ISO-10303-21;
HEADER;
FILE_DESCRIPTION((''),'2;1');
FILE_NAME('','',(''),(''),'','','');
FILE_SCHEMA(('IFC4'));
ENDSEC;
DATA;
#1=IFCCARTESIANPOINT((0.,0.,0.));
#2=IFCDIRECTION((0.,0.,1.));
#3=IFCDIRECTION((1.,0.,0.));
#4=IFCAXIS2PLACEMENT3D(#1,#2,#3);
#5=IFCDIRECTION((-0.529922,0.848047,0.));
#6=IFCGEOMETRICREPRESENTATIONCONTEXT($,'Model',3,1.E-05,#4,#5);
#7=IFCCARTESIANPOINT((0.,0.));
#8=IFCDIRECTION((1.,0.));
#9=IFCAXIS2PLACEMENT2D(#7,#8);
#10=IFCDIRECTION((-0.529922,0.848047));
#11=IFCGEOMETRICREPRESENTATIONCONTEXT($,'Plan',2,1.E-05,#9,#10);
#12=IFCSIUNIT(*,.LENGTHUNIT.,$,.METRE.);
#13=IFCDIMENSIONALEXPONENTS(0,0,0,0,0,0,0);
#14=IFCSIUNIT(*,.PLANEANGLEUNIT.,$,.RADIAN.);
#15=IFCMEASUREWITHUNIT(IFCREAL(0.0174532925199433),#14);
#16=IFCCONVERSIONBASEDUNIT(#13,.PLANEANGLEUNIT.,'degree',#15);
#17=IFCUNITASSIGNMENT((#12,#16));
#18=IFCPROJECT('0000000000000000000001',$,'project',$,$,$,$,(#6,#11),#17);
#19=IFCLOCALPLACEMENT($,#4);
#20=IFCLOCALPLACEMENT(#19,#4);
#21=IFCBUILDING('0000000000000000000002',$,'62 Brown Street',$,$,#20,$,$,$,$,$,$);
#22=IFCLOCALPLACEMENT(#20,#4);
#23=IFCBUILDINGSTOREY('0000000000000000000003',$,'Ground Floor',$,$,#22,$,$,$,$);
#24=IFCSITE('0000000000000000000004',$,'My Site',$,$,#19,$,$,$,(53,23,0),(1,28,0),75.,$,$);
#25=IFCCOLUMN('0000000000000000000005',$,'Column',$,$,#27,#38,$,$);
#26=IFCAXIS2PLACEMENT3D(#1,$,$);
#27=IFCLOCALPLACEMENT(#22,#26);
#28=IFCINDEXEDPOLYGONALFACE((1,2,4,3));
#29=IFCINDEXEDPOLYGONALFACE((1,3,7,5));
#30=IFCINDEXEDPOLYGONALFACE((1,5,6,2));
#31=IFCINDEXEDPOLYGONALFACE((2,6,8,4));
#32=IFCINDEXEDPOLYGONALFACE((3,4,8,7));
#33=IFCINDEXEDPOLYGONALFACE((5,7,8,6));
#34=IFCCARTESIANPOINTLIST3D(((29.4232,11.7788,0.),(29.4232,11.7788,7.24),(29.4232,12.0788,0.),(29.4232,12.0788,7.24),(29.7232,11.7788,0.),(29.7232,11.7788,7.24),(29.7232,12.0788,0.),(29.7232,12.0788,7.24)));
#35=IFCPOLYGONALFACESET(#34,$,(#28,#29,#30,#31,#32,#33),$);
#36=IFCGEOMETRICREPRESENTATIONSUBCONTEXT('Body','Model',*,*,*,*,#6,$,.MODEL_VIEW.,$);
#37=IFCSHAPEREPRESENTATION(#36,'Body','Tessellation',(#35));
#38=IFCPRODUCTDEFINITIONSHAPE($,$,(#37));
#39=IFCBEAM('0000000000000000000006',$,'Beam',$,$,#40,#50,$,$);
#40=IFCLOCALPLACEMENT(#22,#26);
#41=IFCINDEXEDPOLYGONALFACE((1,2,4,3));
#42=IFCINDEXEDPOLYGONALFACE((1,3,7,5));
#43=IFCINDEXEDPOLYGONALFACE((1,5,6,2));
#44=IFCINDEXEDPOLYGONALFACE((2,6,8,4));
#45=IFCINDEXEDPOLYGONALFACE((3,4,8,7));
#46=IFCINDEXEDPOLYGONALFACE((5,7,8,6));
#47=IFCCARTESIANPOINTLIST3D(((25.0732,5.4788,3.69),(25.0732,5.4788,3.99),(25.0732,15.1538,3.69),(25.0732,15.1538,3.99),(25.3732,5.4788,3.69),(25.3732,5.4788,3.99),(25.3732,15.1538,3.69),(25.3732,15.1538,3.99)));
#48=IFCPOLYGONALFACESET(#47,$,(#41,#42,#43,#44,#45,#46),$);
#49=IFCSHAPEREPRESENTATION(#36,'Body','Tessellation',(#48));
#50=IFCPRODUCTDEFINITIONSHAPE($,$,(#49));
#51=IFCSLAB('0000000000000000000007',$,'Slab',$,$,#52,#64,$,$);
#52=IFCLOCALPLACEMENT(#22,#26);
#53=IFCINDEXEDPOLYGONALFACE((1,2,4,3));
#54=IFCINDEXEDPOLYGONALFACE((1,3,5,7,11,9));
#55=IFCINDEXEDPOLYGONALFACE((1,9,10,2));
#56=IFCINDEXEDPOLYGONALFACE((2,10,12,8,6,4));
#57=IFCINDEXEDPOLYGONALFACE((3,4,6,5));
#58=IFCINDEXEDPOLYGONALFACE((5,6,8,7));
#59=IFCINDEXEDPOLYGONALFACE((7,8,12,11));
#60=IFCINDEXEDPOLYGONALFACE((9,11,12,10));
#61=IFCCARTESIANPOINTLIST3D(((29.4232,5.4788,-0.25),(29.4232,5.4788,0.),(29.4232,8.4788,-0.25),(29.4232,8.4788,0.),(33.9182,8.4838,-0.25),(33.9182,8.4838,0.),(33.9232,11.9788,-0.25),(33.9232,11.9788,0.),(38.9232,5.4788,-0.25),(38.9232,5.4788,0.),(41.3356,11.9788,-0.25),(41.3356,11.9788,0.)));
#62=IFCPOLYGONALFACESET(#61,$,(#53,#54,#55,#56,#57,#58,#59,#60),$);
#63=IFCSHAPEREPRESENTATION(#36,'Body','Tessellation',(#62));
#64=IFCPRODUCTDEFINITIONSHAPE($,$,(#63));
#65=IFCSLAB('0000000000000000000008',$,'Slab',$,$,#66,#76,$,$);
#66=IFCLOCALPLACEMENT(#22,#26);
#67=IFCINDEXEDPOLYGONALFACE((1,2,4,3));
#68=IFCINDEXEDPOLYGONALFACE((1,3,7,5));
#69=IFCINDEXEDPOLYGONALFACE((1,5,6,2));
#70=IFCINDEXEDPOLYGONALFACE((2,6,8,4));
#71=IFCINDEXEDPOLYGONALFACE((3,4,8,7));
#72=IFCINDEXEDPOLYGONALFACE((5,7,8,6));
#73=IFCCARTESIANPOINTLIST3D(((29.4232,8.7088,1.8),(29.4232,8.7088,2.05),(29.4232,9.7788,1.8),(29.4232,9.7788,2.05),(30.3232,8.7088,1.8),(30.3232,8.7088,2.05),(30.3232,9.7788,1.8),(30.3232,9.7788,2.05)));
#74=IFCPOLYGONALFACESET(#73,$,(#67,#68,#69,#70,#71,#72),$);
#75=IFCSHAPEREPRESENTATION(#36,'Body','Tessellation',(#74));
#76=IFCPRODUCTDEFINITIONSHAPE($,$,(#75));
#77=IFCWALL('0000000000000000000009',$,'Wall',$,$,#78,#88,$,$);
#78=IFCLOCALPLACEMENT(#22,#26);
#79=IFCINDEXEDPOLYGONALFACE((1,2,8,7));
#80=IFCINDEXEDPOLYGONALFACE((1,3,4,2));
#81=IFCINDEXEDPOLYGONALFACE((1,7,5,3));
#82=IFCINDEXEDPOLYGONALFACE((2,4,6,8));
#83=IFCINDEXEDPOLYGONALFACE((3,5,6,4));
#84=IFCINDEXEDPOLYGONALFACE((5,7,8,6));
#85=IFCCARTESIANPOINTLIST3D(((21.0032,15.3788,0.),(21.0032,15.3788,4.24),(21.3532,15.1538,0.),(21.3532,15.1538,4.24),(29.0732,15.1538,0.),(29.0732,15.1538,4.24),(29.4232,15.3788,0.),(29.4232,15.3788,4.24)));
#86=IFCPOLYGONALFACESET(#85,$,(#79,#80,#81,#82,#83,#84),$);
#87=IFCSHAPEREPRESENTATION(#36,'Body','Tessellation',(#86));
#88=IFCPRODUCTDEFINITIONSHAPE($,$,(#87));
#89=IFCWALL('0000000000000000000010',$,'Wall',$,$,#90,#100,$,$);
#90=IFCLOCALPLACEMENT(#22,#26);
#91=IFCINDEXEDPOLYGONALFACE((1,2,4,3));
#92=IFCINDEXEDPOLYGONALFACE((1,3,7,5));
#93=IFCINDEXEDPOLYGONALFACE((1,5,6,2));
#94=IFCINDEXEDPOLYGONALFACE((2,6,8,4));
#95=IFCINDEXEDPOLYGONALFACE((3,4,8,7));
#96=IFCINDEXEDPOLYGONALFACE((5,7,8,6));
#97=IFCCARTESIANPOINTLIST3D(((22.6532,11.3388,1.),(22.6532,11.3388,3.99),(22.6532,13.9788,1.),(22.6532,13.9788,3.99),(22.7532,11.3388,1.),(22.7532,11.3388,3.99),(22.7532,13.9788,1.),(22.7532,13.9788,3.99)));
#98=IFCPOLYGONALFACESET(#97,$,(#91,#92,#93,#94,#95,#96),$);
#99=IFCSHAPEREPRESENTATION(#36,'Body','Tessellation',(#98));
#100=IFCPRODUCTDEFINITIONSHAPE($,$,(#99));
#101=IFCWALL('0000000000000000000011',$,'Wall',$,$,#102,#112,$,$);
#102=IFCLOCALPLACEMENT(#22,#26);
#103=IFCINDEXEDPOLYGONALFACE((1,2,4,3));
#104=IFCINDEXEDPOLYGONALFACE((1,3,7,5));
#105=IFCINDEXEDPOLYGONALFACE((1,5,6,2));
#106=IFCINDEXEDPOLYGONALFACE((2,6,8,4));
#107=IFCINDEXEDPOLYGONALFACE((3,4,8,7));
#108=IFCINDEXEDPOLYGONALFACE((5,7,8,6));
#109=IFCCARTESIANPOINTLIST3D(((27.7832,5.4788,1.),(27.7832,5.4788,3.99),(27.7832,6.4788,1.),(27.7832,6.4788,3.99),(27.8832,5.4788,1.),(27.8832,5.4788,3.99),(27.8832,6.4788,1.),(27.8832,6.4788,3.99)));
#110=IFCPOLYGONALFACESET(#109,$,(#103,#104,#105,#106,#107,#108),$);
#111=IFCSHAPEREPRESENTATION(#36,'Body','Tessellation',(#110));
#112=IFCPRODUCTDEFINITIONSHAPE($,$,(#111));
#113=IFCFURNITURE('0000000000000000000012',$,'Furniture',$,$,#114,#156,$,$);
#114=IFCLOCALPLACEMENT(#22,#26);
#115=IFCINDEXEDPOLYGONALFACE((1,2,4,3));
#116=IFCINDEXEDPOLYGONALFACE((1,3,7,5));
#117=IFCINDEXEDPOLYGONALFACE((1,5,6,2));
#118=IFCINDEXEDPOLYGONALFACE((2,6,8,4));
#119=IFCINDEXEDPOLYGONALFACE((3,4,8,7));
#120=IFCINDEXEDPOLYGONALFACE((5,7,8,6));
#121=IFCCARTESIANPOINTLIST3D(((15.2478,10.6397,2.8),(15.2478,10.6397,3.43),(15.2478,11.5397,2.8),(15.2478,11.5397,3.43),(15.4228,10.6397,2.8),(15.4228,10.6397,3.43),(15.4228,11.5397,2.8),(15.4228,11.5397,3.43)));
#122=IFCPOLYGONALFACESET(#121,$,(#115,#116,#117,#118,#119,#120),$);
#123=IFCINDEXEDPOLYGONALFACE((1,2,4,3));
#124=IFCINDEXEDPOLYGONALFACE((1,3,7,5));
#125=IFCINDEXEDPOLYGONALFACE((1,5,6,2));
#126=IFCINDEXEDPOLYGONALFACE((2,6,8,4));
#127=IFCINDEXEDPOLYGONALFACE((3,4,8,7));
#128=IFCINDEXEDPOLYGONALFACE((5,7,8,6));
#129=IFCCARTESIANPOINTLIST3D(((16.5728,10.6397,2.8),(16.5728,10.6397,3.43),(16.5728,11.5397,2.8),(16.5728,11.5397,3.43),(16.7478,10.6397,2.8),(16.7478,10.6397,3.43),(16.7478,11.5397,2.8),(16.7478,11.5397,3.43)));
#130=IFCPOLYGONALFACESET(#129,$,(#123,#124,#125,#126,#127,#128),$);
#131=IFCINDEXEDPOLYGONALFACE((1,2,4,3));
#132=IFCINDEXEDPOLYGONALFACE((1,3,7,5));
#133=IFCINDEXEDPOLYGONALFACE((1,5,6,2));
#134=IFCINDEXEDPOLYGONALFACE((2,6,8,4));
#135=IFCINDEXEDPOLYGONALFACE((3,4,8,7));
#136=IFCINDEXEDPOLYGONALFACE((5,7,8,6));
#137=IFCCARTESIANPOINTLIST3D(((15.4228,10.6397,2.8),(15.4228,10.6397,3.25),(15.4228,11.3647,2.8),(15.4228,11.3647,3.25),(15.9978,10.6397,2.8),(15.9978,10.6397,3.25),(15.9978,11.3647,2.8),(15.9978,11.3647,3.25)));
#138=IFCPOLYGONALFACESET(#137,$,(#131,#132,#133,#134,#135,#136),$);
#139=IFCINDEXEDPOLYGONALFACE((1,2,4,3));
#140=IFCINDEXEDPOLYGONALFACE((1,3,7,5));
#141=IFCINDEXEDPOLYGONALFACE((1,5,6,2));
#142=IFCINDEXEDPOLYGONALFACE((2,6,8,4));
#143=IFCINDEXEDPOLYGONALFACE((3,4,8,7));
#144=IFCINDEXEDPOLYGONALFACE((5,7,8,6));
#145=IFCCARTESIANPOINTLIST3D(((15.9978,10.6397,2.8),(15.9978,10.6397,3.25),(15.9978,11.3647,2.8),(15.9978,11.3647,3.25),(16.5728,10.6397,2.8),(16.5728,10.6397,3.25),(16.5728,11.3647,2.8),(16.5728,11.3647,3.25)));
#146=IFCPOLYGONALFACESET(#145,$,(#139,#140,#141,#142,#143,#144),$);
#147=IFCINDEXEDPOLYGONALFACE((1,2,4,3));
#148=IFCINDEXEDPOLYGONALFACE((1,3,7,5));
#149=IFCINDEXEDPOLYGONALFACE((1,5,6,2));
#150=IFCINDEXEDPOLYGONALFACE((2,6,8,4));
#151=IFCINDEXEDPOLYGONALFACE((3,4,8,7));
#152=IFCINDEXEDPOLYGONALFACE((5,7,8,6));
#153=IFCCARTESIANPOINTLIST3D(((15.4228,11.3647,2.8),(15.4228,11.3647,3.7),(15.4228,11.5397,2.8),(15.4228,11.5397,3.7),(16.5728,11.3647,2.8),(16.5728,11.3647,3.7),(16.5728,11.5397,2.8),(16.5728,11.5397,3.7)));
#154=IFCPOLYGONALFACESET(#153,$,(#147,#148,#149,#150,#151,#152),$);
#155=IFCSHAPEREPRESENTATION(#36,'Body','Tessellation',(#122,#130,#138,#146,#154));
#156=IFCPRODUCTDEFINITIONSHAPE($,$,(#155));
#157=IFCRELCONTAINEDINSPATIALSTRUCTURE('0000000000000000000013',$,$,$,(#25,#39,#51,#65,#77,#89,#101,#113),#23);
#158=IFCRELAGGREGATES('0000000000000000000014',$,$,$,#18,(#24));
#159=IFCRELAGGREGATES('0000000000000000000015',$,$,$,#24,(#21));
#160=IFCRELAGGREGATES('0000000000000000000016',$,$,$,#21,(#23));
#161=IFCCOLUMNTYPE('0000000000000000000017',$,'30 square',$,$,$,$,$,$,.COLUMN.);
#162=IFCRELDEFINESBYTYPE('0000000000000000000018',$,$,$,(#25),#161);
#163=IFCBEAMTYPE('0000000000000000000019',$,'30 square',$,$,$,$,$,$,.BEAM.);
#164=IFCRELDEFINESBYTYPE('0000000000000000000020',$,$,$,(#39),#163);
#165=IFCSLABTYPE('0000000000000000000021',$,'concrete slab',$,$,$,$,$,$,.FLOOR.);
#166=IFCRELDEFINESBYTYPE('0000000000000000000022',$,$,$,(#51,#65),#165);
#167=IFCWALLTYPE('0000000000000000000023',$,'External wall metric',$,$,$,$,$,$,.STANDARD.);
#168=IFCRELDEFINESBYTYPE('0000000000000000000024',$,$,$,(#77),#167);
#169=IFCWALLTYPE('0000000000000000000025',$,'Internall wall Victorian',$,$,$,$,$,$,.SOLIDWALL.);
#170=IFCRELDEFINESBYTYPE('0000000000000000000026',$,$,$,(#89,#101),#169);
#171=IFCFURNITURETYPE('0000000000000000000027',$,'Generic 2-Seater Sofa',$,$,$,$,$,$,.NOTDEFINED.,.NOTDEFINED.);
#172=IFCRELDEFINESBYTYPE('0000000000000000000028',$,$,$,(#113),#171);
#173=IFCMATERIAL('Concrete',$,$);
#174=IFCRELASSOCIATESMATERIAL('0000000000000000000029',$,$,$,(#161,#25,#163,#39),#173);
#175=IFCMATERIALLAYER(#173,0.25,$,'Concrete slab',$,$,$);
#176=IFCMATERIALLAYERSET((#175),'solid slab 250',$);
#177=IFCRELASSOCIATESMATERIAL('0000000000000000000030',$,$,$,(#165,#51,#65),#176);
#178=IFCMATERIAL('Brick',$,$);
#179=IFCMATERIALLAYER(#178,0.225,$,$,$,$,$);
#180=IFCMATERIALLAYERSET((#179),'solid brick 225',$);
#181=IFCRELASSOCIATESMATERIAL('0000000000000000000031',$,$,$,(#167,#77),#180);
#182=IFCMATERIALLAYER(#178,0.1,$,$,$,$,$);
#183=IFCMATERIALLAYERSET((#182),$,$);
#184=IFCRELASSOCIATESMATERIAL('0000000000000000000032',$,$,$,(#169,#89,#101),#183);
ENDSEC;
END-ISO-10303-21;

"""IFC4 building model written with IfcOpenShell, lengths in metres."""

from ifc_helpers import new_model, entity, si_unit, converted_unit, direction, frame, origin_with_axes, origin_2d_with_axis, place, context, subcontext, project, spatial, line, indexed_curve, rectangle, outline, extrude, clip, halfspace, shape, source, transform, mapped, material, layer, layer_set, layer_usage, material_profile, profile_set, profile_usage, type_object, type_shapes, element, save


model = new_model("IFC4")

# Units and contexts
model_context = context("Model", 3, precision=1e-05, world=origin_with_axes(), true_north=direction((-0.529922, 0.848047, 0.0)))
plan_context = context("Plan", 2, precision=1e-05, world=origin_2d_with_axis(), true_north=direction((-0.529922, 0.848047)))
body_context_1 = subcontext(model_context, "Body", "Model", "MODEL_VIEW")
body_context_2 = subcontext(plan_context, "Body", "Plan", "PLAN_VIEW")
ifc_project = project(units=[si_unit("LENGTHUNIT", "METRE"), converted_unit("PLANEANGLEUNIT", "degree", entity("IfcReal", 0.0174532925199433), si_unit("PLANEANGLEUNIT", "RADIAN"), dimensions=[0, 0, 0, 0, 0, 0, 0])], contexts=[model_context, plan_context])

# Site, building, storey
site_placement = place(None, origin_with_axes())
site = spatial("IfcSite", under=ifc_project, at=site_placement, Name="My Site", RefLatitude=(53, 23, 0), RefLongitude=(1, 28, 0), RefElevation=75.0)
building_placement = place(site_placement, origin_with_axes())
building = spatial("IfcBuilding", under=site, at=building_placement, Name="62 Brown Street")
storey_placement = place(building_placement, origin_with_axes())
storey = spatial("IfcBuildingStorey", under=building, at=storey_placement, Name="Ground Floor")

# Column
ifc_material_1 = material(Name="Concrete")
ifc_material_profile_1 = material_profile(ifc_material_1, rectangle(XDim=0.3, YDim=0.3))
ifc_profile_set_1 = profile_set([ifc_material_profile_1])
ifc_profile_usage_1 = profile_usage(ifc_profile_set_1, cardinal=5)
column_type = type_object("IfcColumnType", Name="30 square", PredefinedType="COLUMN", material=ifc_profile_set_1)
column_1_placement = place(storey_placement, frame((29.5732, 11.9288, 0.0), z_axis=(0.0, 0.0, 1.0), x_axis=(1.0, 0.0, 0.0)))
element("IfcColumn", 1, at=column_1_placement, inside=storey, type_object=column_type, material=ifc_profile_usage_1, Name="Column", context=body_context_1, shape_type="SweptSolid", body=[
    extrude(rectangle(XDim=0.3, YDim=0.3), origin_with_axes(), (0.0, 0.0, 1.0), 7.24),
])

# Beam
ifc_material_profile_2 = material_profile(ifc_material_1, rectangle(XDim=0.3, YDim=0.3))
ifc_profile_set_2 = profile_set([ifc_material_profile_2])
ifc_profile_usage_2 = profile_usage(ifc_profile_set_2, cardinal=5)
beam_type = type_object("IfcBeamType", Name="30 square", PredefinedType="BEAM", material=ifc_profile_set_2)
beam_placement = place(storey_placement, frame((25.2232, 5.4788, 3.84), z_axis=(0.0, 1.0, 0.0), x_axis=(-1.0, 0.0, 0.0)))
element("IfcBeam", 2, at=beam_placement, inside=storey, type_object=beam_type, material=ifc_profile_usage_2, Name="Beam", context=body_context_1, shape_type="SweptSolid", body=[
    extrude(rectangle(XDim=0.3, YDim=0.3), origin_with_axes(), (0.0, 0.0, 1.0), 9.675),
])

# Slabs
ifc_layer_1 = layer(ifc_material_1, 0.25, Name="Concrete slab")
ifc_layer_set_1 = layer_set([ifc_layer_1], Name="solid slab 250")
ifc_layer_usage_1 = layer_usage(ifc_layer_set_1, "AXIS3", "POSITIVE", 0.0)
slab_type = type_object("IfcSlabType", Name="concrete slab", PredefinedType="FLOOR", material=ifc_layer_set_1)
slab_1_placement = place(storey_placement, frame((29.4232, 5.4788, -0.25), z_axis=(0.0, 0.0, 1.0), x_axis=(1.0, 0.0, 0.0)))
element("IfcSlab", 3, at=slab_1_placement, inside=storey, type_object=slab_type, material=ifc_layer_usage_1, Name="Slab", context=body_context_1, shape_type="SweptSolid", body=[
    extrude(outline(indexed_curve([(0.0, 0.0), (9.5, 0.0), (11.9124, 6.5), (0.0, 3.0), (4.5, 6.5), (4.495, 3.005)], segments=[line(1, 2), line(2, 3), line(3, 5), line(5, 6), line(6, 4), line(4, 1)], self_intersect=False)), None, (0.0, 0.0, 1.0), 0.25),
])
ifc_layer_usage_2 = layer_usage(ifc_layer_set_1, "AXIS3", "POSITIVE", 0.0)
slab_2_placement = place(storey_placement, frame((29.4232, 8.7088, 1.8), z_axis=(0.0, 0.0, 1.0), x_axis=(1.0, 0.0, 0.0)))
element("IfcSlab", 4, at=slab_2_placement, inside=storey, type_object=slab_type, material=ifc_layer_usage_2, Name="Slab", context=body_context_1, shape_type="SweptSolid", body=[
    extrude(outline(indexed_curve([(0.9, 1.07), (0.9, 0.0), (0.0, 0.0), (0.0, 1.07)], segments=[line(3, 2), line(2, 1), line(1, 4), line(4, 3)], self_intersect=False)), None, (0.0, 0.0, 1.0), 0.25),
])

# Walls
ifc_material_2 = material(Name="Brick")
ifc_layer_2 = layer(ifc_material_2, 0.225)
ifc_layer_set_2 = layer_set([ifc_layer_2], Name="solid brick 225")
wall_type_1 = type_object("IfcWallType", Name="External wall metric", PredefinedType="STANDARD", material=ifc_layer_set_2)
ifc_layer_usage_3 = layer_usage(ifc_layer_set_2, "AXIS2", "POSITIVE", 0.0)
wall_1_placement = place(storey_placement, frame((29.4232, 15.3788, 0.0), z_axis=(0.0, 0.0, 1.0), x_axis=(-1.0, 0.0, 0.0)))
element("IfcWall", 5, at=wall_1_placement, inside=storey, type_object=wall_type_1, material=ifc_layer_usage_3, Name="Wall", context=body_context_1, shape_type="Clipping", body=[
    clip(clip(extrude(outline(indexed_curve([(0.0, 0.0), (0.0, 0.225), (8.42, 0.225), (8.42, 0.0), (0.0, 0.0)], self_intersect=False)), origin_with_axes(), (0.0, 0.0, 1.0), 4.24), halfspace(frame((8.42, 0.0, 0.0), z_axis=(0.540756, 0.841179, 0.0), x_axis=(-0.841179, 0.540756, 0.0)), False)), halfspace(frame((0.0, 0.0, 0.0), z_axis=(-0.540758, 0.841178, 0.0), x_axis=(0.841178, 0.540758, 0.0)), False)),
])
ifc_layer_3 = layer(ifc_material_2, 0.1)
ifc_layer_set_3 = layer_set([ifc_layer_3])
ifc_layer_usage_4 = layer_usage(ifc_layer_set_3, "AXIS2", "POSITIVE", 0.0)
wall_type_2 = type_object("IfcWallType", Name="Internall wall Victorian", PredefinedType="SOLIDWALL", material=ifc_layer_set_3)
wall_2_placement = place(storey_placement, frame((22.7532, 11.3388, 1.0), z_axis=(0.0, 0.0, 1.0), x_axis=(0.0, 1.0, 0.0)))
element("IfcWall", 6, at=wall_2_placement, inside=storey, type_object=wall_type_2, material=ifc_layer_usage_4, Name="Wall", context=body_context_1, shape_type="SweptSolid", body=[
    extrude(outline(indexed_curve([(0.0, 0.0), (0.0, 0.1), (2.64, 0.1), (2.64, 0.0), (0.0, 0.0)], self_intersect=False)), origin_with_axes(), (0.0, 0.0, 1.0), 2.99),
])
ifc_layer_usage_5 = layer_usage(ifc_layer_set_3, "AXIS2", "POSITIVE", 0.0)
wall_3_placement = place(storey_placement, frame((27.8832, 5.4788, 1.0), z_axis=(0.0, 0.0, 1.0), x_axis=(0.0, 1.0, 0.0)))
element("IfcWall", 7, at=wall_3_placement, inside=storey, type_object=wall_type_2, material=ifc_layer_usage_5, Name="Wall", context=body_context_1, shape_type="SweptSolid", body=[
    extrude(outline(indexed_curve([(0.0, 0.0), (0.0, 0.1), (1.0, 0.1), (1.0, 0.0), (0.0, 0.0)], self_intersect=False)), origin_with_axes(), (0.0, 0.0, 1.0), 2.99),
])

# Furniture
furniture_type_1 = type_object("IfcFurnitureType", Name="Generic 2-Seater Sofa", AssemblyPlace="NOTDEFINED", PredefinedType="NOTDEFINED")
shared_shape_1 = source(origin_with_axes(), body_context_1, "Body", "SweptSolid", [
    extrude(outline(indexed_curve([(0.0, 0.0), (0.175, 0.0), (0.175, 0.9), (0.0, 0.9)], segments=[line(1, 2, 3, 4, 1)])), frame((-0.75, -0.9, 0.0), z_axis=(0.0, 0.0, 1.0), x_axis=(1.0, 0.0, 0.0)), (0.0, 0.0, 1.0), 0.63),
    extrude(outline(indexed_curve([(0.0, 0.0), (0.175, 0.0), (0.175, 0.9), (0.0, 0.9)], segments=[line(1, 2, 3, 4, 1)])), frame((0.575, -0.9, 0.0), z_axis=(0.0, 0.0, 1.0), x_axis=(1.0, 0.0, 0.0)), (0.0, 0.0, 1.0), 0.63),
    extrude(outline(indexed_curve([(0.175, 0.0), (0.75, 0.0), (0.75, 0.725), (0.175, 0.725)], segments=[line(1, 2, 3, 4, 1)])), frame((-0.75, -0.9, 0.0), z_axis=(0.0, 0.0, 1.0), x_axis=(1.0, 0.0, 0.0)), (0.0, 0.0, 1.0), 0.45),
    extrude(outline(indexed_curve([(0.75, 0.0), (1.325, 0.0), (1.325, 0.725), (0.75, 0.725)], segments=[line(1, 2, 3, 4, 1)])), frame((-0.75, -0.9, 0.0), z_axis=(0.0, 0.0, 1.0), x_axis=(1.0, 0.0, 0.0)), (0.0, 0.0, 1.0), 0.45),
    extrude(outline(indexed_curve([(0.175, 0.725), (1.325, 0.725), (1.325, 0.9), (0.175, 0.9)], segments=[line(1, 2, 3, 4, 1)])), frame((-0.75, -0.9, 0.0), z_axis=(0.0, 0.0, 1.0), x_axis=(1.0, 0.0, 0.0)), (0.0, 0.0, 1.0), 0.9),
])
shared_shape_2 = source(origin_with_axes(), body_context_2, "Body", "Curve2D", [
    entity("IfcIndexedPolyCurve", entity("IfcCartesianPointList2D", [[-0.75, -0.9], [-0.575, -0.9], [-0.575, 0.0], [-0.75, 0.0]]), [entity("IfcLineIndex", [1, 2, 3, 4, 1])]),
    entity("IfcIndexedPolyCurve", entity("IfcCartesianPointList2D", [[0.575, -0.9], [0.75, -0.9], [0.75, 0.0], [0.575, 0.0]]), [entity("IfcLineIndex", [1, 2, 3, 4, 1])]),
    entity("IfcIndexedPolyCurve", entity("IfcCartesianPointList2D", [[-0.575, -0.9], [0.0, -0.9], [0.0, -0.175], [-0.575, -0.175]]), [entity("IfcLineIndex", [1, 2, 3, 4, 1])]),
    entity("IfcIndexedPolyCurve", entity("IfcCartesianPointList2D", [[0.0, -0.9], [0.575, -0.9], [0.575, -0.175], [0.0, -0.175]]), [entity("IfcLineIndex", [1, 2, 3, 4, 1])]),
    entity("IfcIndexedPolyCurve", entity("IfcCartesianPointList2D", [[-0.575, -0.175], [0.575, -0.175], [0.575, 0.0], [-0.575, 0.0]]), [entity("IfcLineIndex", [1, 2, 3, 4, 1])]),
])
type_shapes(furniture_type_1, [shared_shape_1, shared_shape_2])
furniture_1_placement = place(storey_placement, frame((15.9978, 11.5397, 2.8), z_axis=(0.0, 0.0, 1.0), x_axis=(1.0, 0.0, 0.0)))
element("IfcFurniture", 8, at=furniture_1_placement, inside=storey, type_object=furniture_type_1, Name="Furniture", shapes=[
    shape(body_context_1, "Body", "MappedRepresentation", [mapped(shared_shape_1, transform((0.0, 0.0, 0.0), x_axis=(1.0, 0.0, 0.0), y_axis=(0.0, 1.0, 0.0), z_axis=(0.0, 0.0, 1.0), scale=1.0))]),
    shape(body_context_2, "Body", "MappedRepresentation", [mapped(shared_shape_2, transform((0.0, 0.0, 0.0), x_axis=(1.0, 0.0, 0.0), y_axis=(0.0, 1.0, 0.0), z_axis=(0.0, 0.0, 1.0), scale=1.0))]),
])

save(model, "model.ifc")
